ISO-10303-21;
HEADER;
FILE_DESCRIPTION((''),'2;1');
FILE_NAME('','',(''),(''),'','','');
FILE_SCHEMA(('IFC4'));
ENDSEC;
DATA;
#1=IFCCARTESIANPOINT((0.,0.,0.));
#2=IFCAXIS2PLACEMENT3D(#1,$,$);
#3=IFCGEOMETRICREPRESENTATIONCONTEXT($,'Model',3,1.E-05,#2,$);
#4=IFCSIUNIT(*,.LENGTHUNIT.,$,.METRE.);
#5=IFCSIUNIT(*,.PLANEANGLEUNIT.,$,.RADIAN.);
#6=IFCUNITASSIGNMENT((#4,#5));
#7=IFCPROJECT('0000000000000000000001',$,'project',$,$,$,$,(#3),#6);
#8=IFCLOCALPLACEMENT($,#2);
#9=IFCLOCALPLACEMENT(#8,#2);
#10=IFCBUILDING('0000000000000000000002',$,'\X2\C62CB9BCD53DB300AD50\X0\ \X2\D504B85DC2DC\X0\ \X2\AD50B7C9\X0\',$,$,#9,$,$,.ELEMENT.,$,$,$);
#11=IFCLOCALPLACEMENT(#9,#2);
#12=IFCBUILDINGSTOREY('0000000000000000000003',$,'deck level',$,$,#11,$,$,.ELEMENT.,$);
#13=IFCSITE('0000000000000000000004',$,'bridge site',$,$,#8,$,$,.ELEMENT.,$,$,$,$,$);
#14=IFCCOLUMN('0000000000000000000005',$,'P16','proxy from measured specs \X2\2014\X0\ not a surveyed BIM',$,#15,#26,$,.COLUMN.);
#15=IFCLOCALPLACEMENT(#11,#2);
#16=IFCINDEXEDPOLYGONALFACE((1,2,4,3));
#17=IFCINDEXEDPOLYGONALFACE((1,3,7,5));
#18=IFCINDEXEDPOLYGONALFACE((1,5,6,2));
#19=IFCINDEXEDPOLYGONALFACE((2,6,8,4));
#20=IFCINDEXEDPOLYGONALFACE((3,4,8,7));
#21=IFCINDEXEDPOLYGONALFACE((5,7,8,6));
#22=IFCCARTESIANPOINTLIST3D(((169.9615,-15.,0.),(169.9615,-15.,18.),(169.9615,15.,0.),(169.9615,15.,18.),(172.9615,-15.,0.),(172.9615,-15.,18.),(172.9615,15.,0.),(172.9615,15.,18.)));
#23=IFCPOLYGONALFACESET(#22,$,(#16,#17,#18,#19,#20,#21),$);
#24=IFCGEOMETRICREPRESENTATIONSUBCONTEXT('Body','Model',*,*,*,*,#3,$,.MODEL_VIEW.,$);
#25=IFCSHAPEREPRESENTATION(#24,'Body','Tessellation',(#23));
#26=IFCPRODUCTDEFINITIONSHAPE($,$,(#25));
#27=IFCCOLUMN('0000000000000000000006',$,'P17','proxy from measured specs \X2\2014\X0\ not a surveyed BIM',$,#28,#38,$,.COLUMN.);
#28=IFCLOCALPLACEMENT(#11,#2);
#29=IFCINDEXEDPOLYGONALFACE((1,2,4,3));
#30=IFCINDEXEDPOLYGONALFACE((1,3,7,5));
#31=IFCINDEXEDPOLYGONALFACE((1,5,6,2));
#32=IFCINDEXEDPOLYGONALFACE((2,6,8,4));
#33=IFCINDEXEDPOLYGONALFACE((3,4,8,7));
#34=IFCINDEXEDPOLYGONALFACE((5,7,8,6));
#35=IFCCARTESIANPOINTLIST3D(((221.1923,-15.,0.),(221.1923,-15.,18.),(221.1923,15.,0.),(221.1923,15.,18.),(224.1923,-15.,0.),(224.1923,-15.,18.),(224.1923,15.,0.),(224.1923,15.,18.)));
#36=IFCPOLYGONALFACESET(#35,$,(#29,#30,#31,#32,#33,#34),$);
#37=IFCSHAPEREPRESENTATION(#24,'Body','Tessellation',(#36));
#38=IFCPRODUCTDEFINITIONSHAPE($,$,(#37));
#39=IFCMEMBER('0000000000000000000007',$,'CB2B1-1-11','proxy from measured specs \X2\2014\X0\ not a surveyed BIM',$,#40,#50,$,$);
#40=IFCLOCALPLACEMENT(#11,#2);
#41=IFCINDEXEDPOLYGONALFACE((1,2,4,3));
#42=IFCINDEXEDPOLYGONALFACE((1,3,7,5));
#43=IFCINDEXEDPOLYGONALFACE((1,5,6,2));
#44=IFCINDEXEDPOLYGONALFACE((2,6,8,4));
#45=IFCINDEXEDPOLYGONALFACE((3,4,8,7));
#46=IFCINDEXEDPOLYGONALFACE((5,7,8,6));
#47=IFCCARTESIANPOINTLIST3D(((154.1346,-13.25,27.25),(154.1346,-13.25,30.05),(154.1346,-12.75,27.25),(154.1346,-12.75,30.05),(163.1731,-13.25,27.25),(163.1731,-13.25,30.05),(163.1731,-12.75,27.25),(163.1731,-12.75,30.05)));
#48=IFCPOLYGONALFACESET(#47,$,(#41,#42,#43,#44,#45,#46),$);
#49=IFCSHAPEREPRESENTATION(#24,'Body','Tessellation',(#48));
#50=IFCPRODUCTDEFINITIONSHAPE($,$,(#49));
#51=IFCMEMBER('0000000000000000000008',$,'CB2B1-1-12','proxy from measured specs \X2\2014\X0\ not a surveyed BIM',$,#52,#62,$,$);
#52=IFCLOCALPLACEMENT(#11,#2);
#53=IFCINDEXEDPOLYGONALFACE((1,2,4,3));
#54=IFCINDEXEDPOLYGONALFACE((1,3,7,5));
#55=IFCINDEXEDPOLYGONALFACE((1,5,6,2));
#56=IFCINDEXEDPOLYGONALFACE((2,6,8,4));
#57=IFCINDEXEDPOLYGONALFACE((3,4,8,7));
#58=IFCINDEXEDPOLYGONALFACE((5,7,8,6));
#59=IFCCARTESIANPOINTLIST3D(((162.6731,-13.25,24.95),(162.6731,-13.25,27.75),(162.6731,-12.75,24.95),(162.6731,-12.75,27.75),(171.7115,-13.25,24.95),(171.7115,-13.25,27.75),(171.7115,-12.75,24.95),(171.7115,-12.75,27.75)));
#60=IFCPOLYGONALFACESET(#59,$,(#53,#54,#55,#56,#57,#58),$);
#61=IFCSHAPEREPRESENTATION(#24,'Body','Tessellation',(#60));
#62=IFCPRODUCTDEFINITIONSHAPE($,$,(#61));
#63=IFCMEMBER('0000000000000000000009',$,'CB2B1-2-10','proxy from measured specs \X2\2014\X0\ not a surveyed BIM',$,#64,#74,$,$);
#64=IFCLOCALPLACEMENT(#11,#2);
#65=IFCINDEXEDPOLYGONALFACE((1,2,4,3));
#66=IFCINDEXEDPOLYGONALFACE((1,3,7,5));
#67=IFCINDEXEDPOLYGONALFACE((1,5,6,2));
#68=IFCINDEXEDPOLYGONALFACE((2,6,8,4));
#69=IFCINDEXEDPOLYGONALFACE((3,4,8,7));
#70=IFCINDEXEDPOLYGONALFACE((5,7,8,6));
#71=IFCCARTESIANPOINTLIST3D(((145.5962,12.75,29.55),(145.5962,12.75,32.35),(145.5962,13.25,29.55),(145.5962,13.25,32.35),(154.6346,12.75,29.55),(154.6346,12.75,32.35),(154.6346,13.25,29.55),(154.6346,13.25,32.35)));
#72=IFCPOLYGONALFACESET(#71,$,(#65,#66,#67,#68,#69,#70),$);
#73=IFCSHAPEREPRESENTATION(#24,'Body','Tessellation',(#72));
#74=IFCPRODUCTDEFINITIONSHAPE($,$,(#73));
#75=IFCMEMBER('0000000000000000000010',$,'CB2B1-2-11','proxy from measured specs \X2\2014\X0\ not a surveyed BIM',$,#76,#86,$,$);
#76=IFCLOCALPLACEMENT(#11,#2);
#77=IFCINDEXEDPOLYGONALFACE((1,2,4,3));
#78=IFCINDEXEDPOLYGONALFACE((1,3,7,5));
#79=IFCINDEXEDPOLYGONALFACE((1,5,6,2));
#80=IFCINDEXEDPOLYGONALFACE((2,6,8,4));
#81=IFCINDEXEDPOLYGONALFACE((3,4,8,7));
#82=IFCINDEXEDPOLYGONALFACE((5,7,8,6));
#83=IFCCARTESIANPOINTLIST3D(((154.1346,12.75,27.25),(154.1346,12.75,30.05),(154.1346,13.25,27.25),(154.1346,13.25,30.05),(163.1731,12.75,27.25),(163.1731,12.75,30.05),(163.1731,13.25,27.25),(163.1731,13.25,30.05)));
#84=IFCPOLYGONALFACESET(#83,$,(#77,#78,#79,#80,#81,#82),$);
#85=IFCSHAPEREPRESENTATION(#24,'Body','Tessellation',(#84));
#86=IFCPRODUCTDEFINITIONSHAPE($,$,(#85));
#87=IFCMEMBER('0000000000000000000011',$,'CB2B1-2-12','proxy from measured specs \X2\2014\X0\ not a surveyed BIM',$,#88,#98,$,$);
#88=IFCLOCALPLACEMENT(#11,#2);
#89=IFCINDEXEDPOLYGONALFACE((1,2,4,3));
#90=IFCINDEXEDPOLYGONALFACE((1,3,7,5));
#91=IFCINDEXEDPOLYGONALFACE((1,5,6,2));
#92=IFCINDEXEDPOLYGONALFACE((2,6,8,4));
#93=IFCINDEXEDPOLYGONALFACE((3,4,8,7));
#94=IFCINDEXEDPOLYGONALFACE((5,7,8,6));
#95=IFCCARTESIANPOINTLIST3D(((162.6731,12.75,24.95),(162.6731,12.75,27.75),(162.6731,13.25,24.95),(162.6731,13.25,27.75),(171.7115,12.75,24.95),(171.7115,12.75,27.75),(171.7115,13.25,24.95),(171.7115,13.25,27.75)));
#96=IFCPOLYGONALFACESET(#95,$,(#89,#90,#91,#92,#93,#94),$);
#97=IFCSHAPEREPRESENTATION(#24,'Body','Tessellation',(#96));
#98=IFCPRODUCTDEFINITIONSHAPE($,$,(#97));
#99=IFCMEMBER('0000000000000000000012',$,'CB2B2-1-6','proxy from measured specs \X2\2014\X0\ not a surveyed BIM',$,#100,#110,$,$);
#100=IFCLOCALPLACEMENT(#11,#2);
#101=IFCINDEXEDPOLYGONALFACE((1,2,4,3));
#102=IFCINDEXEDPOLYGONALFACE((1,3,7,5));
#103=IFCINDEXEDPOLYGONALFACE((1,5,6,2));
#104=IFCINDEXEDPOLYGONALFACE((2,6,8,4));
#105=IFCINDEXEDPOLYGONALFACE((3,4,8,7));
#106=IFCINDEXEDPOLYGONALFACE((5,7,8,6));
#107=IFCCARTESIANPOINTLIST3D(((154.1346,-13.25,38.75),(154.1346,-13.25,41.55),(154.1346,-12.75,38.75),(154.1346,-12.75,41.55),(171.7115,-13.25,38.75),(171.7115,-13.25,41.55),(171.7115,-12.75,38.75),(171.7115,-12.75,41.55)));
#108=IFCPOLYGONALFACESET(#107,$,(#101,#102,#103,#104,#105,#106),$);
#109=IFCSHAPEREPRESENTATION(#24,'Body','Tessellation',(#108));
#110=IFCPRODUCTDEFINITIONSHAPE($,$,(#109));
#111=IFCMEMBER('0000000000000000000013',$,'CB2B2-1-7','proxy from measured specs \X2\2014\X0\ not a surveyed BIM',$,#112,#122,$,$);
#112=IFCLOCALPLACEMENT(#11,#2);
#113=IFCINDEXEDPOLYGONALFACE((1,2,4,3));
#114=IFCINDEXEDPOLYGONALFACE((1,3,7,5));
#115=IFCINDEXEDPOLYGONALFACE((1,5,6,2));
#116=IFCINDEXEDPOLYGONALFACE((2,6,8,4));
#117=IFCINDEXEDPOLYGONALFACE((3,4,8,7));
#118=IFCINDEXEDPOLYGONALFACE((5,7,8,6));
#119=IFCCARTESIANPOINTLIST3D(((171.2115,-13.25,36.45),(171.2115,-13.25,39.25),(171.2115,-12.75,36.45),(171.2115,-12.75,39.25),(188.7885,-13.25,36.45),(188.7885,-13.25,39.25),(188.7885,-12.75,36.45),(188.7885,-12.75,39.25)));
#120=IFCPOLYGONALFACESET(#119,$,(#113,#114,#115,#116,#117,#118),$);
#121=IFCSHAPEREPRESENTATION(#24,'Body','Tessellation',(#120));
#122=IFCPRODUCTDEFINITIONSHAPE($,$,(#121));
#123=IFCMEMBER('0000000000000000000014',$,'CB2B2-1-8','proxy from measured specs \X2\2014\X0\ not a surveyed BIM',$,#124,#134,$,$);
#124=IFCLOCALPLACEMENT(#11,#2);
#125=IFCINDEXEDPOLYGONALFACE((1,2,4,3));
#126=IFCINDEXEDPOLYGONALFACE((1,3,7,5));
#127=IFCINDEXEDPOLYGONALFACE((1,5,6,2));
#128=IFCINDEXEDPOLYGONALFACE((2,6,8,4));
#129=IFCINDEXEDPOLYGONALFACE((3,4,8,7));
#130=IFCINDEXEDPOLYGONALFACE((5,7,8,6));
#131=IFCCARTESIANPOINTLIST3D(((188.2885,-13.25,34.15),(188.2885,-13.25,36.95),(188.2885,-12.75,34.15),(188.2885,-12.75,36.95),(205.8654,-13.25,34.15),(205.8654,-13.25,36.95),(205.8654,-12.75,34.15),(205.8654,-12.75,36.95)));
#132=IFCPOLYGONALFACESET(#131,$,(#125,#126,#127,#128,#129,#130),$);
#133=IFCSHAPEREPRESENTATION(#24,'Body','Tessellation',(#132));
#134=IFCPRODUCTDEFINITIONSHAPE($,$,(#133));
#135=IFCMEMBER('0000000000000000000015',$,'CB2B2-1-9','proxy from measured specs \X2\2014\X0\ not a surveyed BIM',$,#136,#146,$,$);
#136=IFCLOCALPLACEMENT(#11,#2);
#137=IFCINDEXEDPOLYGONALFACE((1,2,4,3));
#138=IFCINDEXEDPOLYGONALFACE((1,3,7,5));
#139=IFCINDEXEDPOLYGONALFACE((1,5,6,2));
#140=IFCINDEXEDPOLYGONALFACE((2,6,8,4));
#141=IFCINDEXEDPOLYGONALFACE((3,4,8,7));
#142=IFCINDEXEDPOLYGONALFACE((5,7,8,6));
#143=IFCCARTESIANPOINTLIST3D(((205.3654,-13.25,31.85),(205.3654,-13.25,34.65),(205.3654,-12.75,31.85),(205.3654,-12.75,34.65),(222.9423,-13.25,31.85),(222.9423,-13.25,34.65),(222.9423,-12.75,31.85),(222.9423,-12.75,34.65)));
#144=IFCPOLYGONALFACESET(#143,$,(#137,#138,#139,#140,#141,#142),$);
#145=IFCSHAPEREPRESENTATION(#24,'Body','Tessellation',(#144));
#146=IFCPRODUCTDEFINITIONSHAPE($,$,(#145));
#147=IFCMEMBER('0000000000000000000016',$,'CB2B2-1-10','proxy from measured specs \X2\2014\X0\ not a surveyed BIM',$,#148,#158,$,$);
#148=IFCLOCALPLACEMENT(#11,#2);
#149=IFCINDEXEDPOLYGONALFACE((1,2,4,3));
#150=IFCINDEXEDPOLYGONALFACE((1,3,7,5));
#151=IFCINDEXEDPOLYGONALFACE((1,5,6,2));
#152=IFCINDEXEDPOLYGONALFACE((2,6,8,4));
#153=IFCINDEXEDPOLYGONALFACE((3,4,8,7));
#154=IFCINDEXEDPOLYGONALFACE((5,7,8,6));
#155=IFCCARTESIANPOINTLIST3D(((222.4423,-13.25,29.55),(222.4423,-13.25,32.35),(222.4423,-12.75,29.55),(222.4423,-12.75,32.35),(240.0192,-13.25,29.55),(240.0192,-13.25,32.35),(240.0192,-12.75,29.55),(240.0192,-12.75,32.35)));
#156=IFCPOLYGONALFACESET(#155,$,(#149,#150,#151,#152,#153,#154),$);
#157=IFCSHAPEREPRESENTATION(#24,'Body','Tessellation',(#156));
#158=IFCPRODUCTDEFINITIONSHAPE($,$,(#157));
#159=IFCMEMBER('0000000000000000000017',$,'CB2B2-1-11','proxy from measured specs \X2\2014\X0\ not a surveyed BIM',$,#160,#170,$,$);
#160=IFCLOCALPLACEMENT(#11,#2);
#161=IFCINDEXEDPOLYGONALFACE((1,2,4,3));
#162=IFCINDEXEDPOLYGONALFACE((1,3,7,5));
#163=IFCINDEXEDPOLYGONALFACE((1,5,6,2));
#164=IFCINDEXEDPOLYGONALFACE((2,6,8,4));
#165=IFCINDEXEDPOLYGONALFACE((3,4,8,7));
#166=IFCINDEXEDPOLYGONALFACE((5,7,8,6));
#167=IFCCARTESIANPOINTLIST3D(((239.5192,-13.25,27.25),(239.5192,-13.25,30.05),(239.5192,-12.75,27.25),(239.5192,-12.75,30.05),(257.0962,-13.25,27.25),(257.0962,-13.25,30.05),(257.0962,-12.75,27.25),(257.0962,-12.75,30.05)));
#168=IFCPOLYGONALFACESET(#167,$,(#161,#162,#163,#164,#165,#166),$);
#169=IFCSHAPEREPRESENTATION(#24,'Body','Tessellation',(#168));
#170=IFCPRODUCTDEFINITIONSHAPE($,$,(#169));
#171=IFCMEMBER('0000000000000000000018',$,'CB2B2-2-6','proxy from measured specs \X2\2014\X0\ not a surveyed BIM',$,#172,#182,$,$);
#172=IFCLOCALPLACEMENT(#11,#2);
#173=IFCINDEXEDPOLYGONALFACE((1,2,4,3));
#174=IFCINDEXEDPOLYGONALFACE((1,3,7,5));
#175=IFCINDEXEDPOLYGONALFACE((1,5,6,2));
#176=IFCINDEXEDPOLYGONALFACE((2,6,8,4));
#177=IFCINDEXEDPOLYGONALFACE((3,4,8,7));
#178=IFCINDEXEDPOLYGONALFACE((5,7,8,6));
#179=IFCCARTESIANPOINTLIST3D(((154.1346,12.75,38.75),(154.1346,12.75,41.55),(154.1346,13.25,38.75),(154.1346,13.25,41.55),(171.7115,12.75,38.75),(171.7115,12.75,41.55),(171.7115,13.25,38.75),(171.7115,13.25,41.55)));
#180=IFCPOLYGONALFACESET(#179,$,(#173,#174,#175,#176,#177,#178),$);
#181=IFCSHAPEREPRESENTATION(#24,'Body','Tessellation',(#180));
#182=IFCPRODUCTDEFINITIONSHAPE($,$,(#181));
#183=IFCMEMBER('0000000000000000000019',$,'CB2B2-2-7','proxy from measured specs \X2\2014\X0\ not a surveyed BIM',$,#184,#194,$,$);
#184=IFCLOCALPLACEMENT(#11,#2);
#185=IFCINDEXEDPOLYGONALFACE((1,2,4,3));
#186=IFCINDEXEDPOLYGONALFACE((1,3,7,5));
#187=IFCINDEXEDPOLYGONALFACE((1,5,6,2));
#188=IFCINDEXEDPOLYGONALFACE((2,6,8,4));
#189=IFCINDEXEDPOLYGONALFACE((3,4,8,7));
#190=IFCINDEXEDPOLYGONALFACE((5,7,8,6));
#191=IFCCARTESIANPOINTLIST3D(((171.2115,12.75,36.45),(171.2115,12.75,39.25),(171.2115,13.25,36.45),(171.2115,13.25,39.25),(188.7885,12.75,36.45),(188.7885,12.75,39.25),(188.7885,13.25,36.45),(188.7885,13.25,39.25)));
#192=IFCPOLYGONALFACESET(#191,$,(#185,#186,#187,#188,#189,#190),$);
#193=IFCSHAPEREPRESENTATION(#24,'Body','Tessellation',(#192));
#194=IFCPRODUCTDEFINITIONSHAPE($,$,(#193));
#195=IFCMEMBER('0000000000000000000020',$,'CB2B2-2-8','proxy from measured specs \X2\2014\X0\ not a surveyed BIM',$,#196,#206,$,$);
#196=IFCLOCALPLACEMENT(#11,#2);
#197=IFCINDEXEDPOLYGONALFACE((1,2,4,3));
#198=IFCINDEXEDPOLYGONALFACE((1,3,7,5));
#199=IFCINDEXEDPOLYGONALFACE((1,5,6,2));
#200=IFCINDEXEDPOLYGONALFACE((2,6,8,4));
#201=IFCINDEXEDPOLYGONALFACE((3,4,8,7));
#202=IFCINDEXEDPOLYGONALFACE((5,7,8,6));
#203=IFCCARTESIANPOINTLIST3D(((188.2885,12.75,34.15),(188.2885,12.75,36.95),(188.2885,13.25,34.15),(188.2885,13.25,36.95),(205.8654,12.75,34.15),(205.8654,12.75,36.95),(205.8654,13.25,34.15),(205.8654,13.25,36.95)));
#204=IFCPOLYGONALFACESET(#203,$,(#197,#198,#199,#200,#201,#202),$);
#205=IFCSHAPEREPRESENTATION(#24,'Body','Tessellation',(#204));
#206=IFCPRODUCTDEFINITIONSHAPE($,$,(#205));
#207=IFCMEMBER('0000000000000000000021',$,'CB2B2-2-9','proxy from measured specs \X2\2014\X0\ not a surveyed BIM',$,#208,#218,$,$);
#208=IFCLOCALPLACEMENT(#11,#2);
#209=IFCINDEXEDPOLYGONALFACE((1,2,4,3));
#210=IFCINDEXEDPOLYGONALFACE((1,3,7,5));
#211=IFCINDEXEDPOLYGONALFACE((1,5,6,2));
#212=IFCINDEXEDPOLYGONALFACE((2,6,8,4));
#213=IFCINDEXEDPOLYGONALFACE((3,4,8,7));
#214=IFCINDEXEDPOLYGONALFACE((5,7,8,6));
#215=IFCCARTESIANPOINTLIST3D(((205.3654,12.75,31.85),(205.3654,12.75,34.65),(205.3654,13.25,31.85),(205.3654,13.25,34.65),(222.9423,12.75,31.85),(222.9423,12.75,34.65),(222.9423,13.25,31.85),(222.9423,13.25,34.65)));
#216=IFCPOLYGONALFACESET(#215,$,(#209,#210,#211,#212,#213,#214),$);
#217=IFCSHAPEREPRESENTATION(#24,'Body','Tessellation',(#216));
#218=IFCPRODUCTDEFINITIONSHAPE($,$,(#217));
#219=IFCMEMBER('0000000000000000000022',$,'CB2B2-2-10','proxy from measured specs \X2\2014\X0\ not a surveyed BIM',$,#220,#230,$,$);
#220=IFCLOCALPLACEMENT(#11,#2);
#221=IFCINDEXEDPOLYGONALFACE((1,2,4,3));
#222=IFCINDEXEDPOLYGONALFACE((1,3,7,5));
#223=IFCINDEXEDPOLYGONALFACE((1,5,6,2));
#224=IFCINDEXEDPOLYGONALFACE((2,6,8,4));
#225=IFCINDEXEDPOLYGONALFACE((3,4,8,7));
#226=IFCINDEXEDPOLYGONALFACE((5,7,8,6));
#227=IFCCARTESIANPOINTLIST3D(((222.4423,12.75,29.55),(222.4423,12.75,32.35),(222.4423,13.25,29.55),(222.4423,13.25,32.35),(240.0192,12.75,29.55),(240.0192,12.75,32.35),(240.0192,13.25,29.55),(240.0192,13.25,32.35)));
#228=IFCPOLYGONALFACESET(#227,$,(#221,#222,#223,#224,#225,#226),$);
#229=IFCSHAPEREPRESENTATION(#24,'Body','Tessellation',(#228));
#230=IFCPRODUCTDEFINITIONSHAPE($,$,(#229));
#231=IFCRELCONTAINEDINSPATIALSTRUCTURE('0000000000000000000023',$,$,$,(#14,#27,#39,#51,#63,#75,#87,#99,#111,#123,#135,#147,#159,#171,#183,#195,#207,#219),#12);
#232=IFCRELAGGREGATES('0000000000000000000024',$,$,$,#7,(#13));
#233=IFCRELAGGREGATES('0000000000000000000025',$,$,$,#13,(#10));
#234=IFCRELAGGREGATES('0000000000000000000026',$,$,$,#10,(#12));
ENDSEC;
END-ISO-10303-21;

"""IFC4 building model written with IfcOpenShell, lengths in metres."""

from ifc_helpers import new_model, si_unit, frame, origin, origin_2d, place, context, subcontext, project, spatial, rectangle, extrude, element, save


model = new_model("IFC4")

# Units and contexts
model_context = context("Model", 3, precision=1e-05, world=origin())
body_context = subcontext(model_context, "Body", "Model", "MODEL_VIEW")
ifc_project = project(units=[si_unit("LENGTHUNIT", "METRE"), si_unit("PLANEANGLEUNIT", "RADIAN")], contexts=[model_context])

# Site, building, storey
site_placement = place(None, origin())
site = spatial("IfcSite", under=ifc_project, at=site_placement, Name="bridge site", CompositionType="ELEMENT")
building_placement = place(site_placement, origin())
building = spatial("IfcBuilding", under=site, at=building_placement, Name="올림픽대교 프록시 교량", CompositionType="ELEMENT")
storey_placement = place(building_placement, origin())
storey = spatial("IfcBuildingStorey", under=building, at=storey_placement, Name="deck level", CompositionType="ELEMENT")

# Columns
for number, where, name in (
    (1, (171.4615, 0.0, 0.0), "P16"),
    (2, (222.6923, 0.0, 0.0), "P17"),
):
    element("IfcColumn", number, at=place(storey_placement, frame(where)), inside=storey, Name=name, Description="proxy from measured specs — not a surveyed BIM", PredefinedType="COLUMN", context=body_context, shape_type="SweptSolid", body=[
        extrude(rectangle(XDim=3.0, YDim=30.0, at=origin_2d()), origin(), (0.0, 0.0, 1.0), 18.0),
    ])

# Members
member_1_placement = place(storey_placement, frame((158.6538, -13.0, 27.25)))
element("IfcMember", 3, at=member_1_placement, inside=storey, Name="CB2B1-1-11", Description="proxy from measured specs — not a surveyed BIM", context=body_context, shape_type="SweptSolid", body=[
    extrude(rectangle(XDim=9.0385, YDim=0.5, at=origin_2d()), origin(), (0.0, 0.0, 1.0), 2.8),
])
member_2_placement = place(storey_placement, frame((167.1923, -13.0, 24.95)))
element("IfcMember", 4, at=member_2_placement, inside=storey, Name="CB2B1-1-12", Description="proxy from measured specs — not a surveyed BIM", context=body_context, shape_type="SweptSolid", body=[
    extrude(rectangle(XDim=9.0385, YDim=0.5, at=origin_2d()), origin(), (0.0, 0.0, 1.0), 2.8),
])
member_3_placement = place(storey_placement, frame((150.1154, 13.0, 29.55)))
element("IfcMember", 5, at=member_3_placement, inside=storey, Name="CB2B1-2-10", Description="proxy from measured specs — not a surveyed BIM", context=body_context, shape_type="SweptSolid", body=[
    extrude(rectangle(XDim=9.0385, YDim=0.5, at=origin_2d()), origin(), (0.0, 0.0, 1.0), 2.8),
])
member_4_placement = place(storey_placement, frame((158.6538, 13.0, 27.25)))
element("IfcMember", 6, at=member_4_placement, inside=storey, Name="CB2B1-2-11", Description="proxy from measured specs — not a surveyed BIM", context=body_context, shape_type="SweptSolid", body=[
    extrude(rectangle(XDim=9.0385, YDim=0.5, at=origin_2d()), origin(), (0.0, 0.0, 1.0), 2.8),
])
member_5_placement = place(storey_placement, frame((167.1923, 13.0, 24.95)))
element("IfcMember", 7, at=member_5_placement, inside=storey, Name="CB2B1-2-12", Description="proxy from measured specs — not a surveyed BIM", context=body_context, shape_type="SweptSolid", body=[
    extrude(rectangle(XDim=9.0385, YDim=0.5, at=origin_2d()), origin(), (0.0, 0.0, 1.0), 2.8),
])
for number, where, name in (
    (8, (162.9231, -13.0, 38.75), "CB2B2-1-6"),
    (9, (180.0, -13.0, 36.45), "CB2B2-1-7"),
):
    element("IfcMember", number, at=place(storey_placement, frame(where)), inside=storey, Name=name, Description="proxy from measured specs — not a surveyed BIM", context=body_context, shape_type="SweptSolid", body=[
        extrude(rectangle(XDim=17.5769, YDim=0.5, at=origin_2d()), origin(), (0.0, 0.0, 1.0), 2.8),
    ])
for number, where, name in (
    (10, (197.0769, -13.0, 34.15), "CB2B2-1-8"),
    (11, (214.1538, -13.0, 31.85), "CB2B2-1-9"),
):
    element("IfcMember", number, at=place(storey_placement, frame(where)), inside=storey, Name=name, Description="proxy from measured specs — not a surveyed BIM", context=body_context, shape_type="SweptSolid", body=[
        extrude(rectangle(XDim=17.5769, YDim=0.5, at=origin_2d()), origin(), (0.0, 0.0, 1.0), 2.8),
    ])
for number, where, name in (
    (12, (231.2308, -13.0, 29.55), "CB2B2-1-10"),
    (13, (248.3077, -13.0, 27.25), "CB2B2-1-11"),
):
    element("IfcMember", number, at=place(storey_placement, frame(where)), inside=storey, Name=name, Description="proxy from measured specs — not a surveyed BIM", context=body_context, shape_type="SweptSolid", body=[
        extrude(rectangle(XDim=17.5769, YDim=0.5, at=origin_2d()), origin(), (0.0, 0.0, 1.0), 2.8),
    ])
for number, where, name in (
    (14, (162.9231, 13.0, 38.75), "CB2B2-2-6"),
    (15, (180.0, 13.0, 36.45), "CB2B2-2-7"),
):
    element("IfcMember", number, at=place(storey_placement, frame(where)), inside=storey, Name=name, Description="proxy from measured specs — not a surveyed BIM", context=body_context, shape_type="SweptSolid", body=[
        extrude(rectangle(XDim=17.5769, YDim=0.5, at=origin_2d()), origin(), (0.0, 0.0, 1.0), 2.8),
    ])
for number, where, name in (
    (16, (197.0769, 13.0, 34.15), "CB2B2-2-8"),
    (17, (214.1538, 13.0, 31.85), "CB2B2-2-9"),
):
    element("IfcMember", number, at=place(storey_placement, frame(where)), inside=storey, Name=name, Description="proxy from measured specs — not a surveyed BIM", context=body_context, shape_type="SweptSolid", body=[
        extrude(rectangle(XDim=17.5769, YDim=0.5, at=origin_2d()), origin(), (0.0, 0.0, 1.0), 2.8),
    ])
member_6_placement = place(storey_placement, frame((231.2308, 13.0, 29.55)))
element("IfcMember", 18, at=member_6_placement, inside=storey, Name="CB2B2-2-10", Description="proxy from measured specs — not a surveyed BIM", context=body_context, shape_type="SweptSolid", body=[
    extrude(rectangle(XDim=17.5769, YDim=0.5, at=origin_2d()), origin(), (0.0, 0.0, 1.0), 2.8),
])

save(model, "model.ifc")
